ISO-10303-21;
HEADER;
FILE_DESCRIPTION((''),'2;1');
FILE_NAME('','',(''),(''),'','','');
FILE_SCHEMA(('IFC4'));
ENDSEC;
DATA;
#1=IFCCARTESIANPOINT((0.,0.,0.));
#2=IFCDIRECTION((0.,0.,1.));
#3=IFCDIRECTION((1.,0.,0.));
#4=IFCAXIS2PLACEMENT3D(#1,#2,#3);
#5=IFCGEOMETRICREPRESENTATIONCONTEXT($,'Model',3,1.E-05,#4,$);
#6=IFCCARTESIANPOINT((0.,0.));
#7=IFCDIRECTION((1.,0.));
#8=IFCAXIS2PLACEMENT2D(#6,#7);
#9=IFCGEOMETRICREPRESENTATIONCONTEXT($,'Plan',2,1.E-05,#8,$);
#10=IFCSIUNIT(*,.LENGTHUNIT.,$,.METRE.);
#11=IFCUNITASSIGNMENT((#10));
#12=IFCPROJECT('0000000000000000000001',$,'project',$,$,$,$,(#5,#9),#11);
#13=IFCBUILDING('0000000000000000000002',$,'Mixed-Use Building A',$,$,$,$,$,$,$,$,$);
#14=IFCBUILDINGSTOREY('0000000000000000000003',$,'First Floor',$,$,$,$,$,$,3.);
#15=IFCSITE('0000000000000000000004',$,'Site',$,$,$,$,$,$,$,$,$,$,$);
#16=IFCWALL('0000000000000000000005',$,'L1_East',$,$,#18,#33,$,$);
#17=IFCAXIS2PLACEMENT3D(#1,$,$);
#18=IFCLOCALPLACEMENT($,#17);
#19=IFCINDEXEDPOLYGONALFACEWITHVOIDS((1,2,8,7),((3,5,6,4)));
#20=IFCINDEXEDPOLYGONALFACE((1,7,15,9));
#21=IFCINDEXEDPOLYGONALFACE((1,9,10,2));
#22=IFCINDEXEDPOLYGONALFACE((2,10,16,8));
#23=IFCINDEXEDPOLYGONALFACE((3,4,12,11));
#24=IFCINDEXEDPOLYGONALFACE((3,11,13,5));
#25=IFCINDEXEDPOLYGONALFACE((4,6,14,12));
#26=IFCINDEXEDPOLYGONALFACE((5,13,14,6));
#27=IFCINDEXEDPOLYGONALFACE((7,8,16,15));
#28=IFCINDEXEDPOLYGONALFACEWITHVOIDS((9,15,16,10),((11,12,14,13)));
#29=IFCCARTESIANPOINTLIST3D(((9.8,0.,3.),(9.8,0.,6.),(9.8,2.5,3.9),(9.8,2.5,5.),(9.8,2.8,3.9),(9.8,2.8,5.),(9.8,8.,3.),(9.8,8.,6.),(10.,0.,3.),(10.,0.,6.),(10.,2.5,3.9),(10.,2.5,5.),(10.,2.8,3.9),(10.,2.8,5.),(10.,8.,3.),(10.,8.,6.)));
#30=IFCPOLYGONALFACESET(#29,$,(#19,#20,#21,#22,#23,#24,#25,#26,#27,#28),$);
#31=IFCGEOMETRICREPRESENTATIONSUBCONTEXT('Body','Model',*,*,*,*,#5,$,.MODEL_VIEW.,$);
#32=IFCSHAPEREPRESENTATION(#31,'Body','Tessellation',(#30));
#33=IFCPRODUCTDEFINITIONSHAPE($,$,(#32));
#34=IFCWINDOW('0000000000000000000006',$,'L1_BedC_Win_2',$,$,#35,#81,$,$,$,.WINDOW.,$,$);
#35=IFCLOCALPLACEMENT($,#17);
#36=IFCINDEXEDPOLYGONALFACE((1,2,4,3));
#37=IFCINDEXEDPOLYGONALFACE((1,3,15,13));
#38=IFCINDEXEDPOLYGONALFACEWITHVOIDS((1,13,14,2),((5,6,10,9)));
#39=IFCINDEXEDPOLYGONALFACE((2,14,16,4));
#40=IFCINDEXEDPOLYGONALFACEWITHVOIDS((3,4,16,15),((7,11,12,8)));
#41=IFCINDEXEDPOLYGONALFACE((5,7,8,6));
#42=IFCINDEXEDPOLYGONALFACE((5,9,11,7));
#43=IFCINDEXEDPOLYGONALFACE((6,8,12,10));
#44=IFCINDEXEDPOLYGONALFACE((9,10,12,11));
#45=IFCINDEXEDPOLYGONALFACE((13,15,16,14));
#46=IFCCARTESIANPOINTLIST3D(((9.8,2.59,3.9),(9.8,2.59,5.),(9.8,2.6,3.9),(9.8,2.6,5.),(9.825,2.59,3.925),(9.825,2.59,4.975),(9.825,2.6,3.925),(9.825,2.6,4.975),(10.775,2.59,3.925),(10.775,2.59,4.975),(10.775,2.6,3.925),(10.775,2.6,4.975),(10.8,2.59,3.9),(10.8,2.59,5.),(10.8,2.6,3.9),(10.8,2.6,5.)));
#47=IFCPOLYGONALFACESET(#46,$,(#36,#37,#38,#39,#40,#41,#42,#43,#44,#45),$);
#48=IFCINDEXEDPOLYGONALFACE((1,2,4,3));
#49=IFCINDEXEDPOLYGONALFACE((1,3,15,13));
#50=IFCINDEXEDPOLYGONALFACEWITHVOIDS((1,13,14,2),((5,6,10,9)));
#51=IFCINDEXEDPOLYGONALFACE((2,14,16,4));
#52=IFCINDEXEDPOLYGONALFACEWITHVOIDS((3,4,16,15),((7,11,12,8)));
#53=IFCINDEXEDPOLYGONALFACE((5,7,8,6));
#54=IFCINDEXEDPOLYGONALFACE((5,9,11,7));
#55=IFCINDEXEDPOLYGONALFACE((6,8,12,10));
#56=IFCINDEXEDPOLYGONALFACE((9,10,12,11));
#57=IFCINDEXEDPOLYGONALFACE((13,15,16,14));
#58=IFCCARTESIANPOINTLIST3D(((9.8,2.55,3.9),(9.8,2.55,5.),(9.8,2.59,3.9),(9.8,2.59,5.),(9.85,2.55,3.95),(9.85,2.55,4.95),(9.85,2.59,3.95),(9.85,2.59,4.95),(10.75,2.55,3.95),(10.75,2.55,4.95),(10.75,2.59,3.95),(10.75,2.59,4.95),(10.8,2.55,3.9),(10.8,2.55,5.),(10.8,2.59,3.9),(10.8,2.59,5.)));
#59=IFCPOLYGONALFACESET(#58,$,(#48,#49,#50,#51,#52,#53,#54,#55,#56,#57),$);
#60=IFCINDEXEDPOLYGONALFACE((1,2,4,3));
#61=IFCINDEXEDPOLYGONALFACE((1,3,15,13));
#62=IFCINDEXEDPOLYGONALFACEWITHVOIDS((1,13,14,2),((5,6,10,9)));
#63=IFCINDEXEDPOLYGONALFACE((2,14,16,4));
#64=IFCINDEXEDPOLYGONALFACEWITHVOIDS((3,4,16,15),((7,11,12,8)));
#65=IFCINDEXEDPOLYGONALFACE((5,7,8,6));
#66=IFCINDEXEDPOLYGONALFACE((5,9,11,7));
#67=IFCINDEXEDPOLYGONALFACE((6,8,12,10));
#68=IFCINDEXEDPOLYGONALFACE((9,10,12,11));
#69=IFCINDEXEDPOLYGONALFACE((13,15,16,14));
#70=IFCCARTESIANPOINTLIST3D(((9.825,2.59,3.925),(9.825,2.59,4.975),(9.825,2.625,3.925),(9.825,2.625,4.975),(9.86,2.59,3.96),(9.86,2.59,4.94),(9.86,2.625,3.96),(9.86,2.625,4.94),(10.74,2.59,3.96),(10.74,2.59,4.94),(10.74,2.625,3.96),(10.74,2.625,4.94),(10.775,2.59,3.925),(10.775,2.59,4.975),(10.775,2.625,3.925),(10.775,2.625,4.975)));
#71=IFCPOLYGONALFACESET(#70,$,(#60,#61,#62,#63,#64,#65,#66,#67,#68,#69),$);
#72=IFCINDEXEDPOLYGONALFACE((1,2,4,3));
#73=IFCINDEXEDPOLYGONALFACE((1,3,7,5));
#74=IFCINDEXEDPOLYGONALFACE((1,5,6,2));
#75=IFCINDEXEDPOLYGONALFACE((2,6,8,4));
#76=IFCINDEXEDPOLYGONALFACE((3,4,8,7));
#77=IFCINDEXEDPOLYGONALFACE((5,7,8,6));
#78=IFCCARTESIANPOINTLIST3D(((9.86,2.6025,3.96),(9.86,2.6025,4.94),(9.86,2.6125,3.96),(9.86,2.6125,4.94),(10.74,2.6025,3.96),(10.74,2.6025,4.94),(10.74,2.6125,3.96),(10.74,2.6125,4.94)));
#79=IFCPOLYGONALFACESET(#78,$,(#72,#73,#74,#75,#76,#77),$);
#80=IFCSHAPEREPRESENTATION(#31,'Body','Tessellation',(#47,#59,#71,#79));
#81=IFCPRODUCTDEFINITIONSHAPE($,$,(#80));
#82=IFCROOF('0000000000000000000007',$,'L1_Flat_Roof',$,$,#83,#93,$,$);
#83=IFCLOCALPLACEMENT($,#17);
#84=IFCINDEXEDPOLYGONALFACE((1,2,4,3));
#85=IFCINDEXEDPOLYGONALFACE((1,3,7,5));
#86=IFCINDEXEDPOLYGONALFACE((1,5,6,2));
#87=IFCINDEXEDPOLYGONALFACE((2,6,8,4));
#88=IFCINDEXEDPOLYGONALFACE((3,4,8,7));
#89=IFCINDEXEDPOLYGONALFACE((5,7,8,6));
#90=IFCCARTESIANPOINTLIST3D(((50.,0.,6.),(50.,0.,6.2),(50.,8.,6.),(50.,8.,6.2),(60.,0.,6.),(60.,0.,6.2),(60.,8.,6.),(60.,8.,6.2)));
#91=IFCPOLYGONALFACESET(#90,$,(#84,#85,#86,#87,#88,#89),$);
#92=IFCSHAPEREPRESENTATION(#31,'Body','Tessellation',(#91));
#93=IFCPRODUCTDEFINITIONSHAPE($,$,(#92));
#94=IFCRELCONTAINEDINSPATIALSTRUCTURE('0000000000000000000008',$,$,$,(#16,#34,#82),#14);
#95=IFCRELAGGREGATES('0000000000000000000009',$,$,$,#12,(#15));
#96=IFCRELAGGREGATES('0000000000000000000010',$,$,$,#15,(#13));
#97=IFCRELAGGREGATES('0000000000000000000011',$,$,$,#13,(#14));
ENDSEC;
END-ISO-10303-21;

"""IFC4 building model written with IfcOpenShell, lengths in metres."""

from ifc_helpers import new_model, si_unit, frame, origin_with_axes, origin_2d_with_axis, place, context, subcontext, project, spatial, line, indexed_curve, outline, extrude, element, fill, save


model = new_model("IFC4")

# Units and contexts
model_context = context("Model", 3, precision=1e-05, world=origin_with_axes())
plan_context = context("Plan", 2, precision=1e-05, world=origin_2d_with_axis())
body_context = subcontext(model_context, "Body", "Model", "MODEL_VIEW")
ifc_project = project(units=[si_unit("LENGTHUNIT", "METRE")], contexts=[model_context, plan_context])

# Site, building, storey
site = spatial("IfcSite", under=ifc_project, Name="Site")
building = spatial("IfcBuilding", under=site, Name="Mixed-Use Building A")
storey = spatial("IfcBuildingStorey", under=building, Name="First Floor", Elevation=3.0)

# Wall, opening, window
wall_1_placement = place(None, frame((10.0, 0.0, 3.0), z_axis=(0.0, 0.0, 1.0), x_axis=(0.0, 1.0, 0.0)))
wall_1 = element("IfcWall", 1, at=wall_1_placement, inside=storey, Name="L1_East", context=body_context, shape_type="SweptSolid", body=[
    extrude(outline(indexed_curve([(0.0, 0.0), (0.0, 0.2), (8.0, 0.2), (8.0, 0.0), (0.0, 0.0)], self_intersect=False)), origin_with_axes(), (0.0, 0.0, 1.0), 3.0),
])
opening_1_placement = place(wall_1_placement, frame((2.5, 0.2, 0.9), z_axis=(0.0, 0.0, 1.0), x_axis=(0.0, -1.0, 0.0)))
opening_1 = element("IfcOpeningElement", 2, at=opening_1_placement, inside=storey, cuts=wall_1, PredefinedType="OPENING", context=body_context, shape_type="SweptSolid", body=[
    extrude(outline(indexed_curve([(0.0, 0.0), (0.0, 0.3), (1.0, 0.3), (1.0, 0.0), (0.0, 0.0)], self_intersect=False)), origin_with_axes(), (0.0, 0.0, 1.0), 1.1),
])
window_1_placement = place(None, frame((9.8, 2.5, 3.9), z_axis=(0.0, 0.0, 1.0), x_axis=(1.0, 0.0, 0.0)))
window_1 = element("IfcWindow", 3, at=window_1_placement, inside=storey, Name="L1_BedC_Win_2", PredefinedType="WINDOW", context=body_context, shape_type="SweptSolid", body=[
    extrude(outline(indexed_curve([(0.0, 0.0), (1.0, 0.0), (1.0, 1.1), (0.0, 1.1)], segments=[line(1, 2, 3, 4, 1)]), holes=[indexed_curve([(0.025, 0.025), (0.975, 0.025), (0.975, 1.075), (0.025, 1.075)], segments=[line(1, 2, 3, 4, 1)])]), frame((0.0, 0.09, 0.0), z_axis=(0.0, -1.0, 0.0), x_axis=(1.0, 0.0, 0.0)), (0.0, 0.0, -1.0), 0.01),
    extrude(outline(indexed_curve([(0.0, 0.0), (1.0, 0.0), (1.0, 1.1), (0.0, 1.1)], segments=[line(1, 2, 3, 4, 1)]), holes=[indexed_curve([(0.05, 0.05), (0.95, 0.05), (0.95, 1.05), (0.05, 1.05)], segments=[line(1, 2, 3, 4, 1)])]), frame((0.0, 0.05, 0.0), z_axis=(0.0, -1.0, 0.0), x_axis=(1.0, 0.0, 0.0)), (0.0, 0.0, -1.0), 0.04),
    extrude(outline(indexed_curve([(0.0, 0.0), (0.95, 0.0), (0.95, 1.05), (0.0, 1.05)], segments=[line(1, 2, 3, 4, 1)]), holes=[indexed_curve([(0.035, 0.035), (0.915, 0.035), (0.915, 1.015), (0.035, 1.015)], segments=[line(1, 2, 3, 4, 1)])]), frame((0.025, 0.09, 0.025), z_axis=(0.0, -1.0, 0.0), x_axis=(1.0, 0.0, 0.0)), (0.0, 0.0, -1.0), 0.035),
    extrude(outline(indexed_curve([(0.035, 0.035), (0.915, 0.035), (0.915, 1.015), (0.035, 1.015)], segments=[line(1, 2, 3, 4, 1)])), frame((0.025, 0.1025, 0.025), z_axis=(0.0, -1.0, 0.0), x_axis=(1.0, 0.0, 0.0)), (0.0, 0.0, -1.0), 0.01),
])
fill(opening_1, window_1)

# Roof
roof_placement = place(None, frame((50.0, 0.0, 6.0), z_axis=(0.0, 0.0, 1.0), x_axis=(1.0, 0.0, 0.0)))
element("IfcRoof", 4, at=roof_placement, inside=storey, Name="L1_Flat_Roof", context=body_context, shape_type="SweptSolid", body=[
    extrude(outline(indexed_curve([(0.0, 0.0), (10.0, 0.0), (10.0, 8.0), (0.0, 8.0)])), None, (0.0, 0.0, 1.0), 0.2),
])

save(model, "model.ifc")
